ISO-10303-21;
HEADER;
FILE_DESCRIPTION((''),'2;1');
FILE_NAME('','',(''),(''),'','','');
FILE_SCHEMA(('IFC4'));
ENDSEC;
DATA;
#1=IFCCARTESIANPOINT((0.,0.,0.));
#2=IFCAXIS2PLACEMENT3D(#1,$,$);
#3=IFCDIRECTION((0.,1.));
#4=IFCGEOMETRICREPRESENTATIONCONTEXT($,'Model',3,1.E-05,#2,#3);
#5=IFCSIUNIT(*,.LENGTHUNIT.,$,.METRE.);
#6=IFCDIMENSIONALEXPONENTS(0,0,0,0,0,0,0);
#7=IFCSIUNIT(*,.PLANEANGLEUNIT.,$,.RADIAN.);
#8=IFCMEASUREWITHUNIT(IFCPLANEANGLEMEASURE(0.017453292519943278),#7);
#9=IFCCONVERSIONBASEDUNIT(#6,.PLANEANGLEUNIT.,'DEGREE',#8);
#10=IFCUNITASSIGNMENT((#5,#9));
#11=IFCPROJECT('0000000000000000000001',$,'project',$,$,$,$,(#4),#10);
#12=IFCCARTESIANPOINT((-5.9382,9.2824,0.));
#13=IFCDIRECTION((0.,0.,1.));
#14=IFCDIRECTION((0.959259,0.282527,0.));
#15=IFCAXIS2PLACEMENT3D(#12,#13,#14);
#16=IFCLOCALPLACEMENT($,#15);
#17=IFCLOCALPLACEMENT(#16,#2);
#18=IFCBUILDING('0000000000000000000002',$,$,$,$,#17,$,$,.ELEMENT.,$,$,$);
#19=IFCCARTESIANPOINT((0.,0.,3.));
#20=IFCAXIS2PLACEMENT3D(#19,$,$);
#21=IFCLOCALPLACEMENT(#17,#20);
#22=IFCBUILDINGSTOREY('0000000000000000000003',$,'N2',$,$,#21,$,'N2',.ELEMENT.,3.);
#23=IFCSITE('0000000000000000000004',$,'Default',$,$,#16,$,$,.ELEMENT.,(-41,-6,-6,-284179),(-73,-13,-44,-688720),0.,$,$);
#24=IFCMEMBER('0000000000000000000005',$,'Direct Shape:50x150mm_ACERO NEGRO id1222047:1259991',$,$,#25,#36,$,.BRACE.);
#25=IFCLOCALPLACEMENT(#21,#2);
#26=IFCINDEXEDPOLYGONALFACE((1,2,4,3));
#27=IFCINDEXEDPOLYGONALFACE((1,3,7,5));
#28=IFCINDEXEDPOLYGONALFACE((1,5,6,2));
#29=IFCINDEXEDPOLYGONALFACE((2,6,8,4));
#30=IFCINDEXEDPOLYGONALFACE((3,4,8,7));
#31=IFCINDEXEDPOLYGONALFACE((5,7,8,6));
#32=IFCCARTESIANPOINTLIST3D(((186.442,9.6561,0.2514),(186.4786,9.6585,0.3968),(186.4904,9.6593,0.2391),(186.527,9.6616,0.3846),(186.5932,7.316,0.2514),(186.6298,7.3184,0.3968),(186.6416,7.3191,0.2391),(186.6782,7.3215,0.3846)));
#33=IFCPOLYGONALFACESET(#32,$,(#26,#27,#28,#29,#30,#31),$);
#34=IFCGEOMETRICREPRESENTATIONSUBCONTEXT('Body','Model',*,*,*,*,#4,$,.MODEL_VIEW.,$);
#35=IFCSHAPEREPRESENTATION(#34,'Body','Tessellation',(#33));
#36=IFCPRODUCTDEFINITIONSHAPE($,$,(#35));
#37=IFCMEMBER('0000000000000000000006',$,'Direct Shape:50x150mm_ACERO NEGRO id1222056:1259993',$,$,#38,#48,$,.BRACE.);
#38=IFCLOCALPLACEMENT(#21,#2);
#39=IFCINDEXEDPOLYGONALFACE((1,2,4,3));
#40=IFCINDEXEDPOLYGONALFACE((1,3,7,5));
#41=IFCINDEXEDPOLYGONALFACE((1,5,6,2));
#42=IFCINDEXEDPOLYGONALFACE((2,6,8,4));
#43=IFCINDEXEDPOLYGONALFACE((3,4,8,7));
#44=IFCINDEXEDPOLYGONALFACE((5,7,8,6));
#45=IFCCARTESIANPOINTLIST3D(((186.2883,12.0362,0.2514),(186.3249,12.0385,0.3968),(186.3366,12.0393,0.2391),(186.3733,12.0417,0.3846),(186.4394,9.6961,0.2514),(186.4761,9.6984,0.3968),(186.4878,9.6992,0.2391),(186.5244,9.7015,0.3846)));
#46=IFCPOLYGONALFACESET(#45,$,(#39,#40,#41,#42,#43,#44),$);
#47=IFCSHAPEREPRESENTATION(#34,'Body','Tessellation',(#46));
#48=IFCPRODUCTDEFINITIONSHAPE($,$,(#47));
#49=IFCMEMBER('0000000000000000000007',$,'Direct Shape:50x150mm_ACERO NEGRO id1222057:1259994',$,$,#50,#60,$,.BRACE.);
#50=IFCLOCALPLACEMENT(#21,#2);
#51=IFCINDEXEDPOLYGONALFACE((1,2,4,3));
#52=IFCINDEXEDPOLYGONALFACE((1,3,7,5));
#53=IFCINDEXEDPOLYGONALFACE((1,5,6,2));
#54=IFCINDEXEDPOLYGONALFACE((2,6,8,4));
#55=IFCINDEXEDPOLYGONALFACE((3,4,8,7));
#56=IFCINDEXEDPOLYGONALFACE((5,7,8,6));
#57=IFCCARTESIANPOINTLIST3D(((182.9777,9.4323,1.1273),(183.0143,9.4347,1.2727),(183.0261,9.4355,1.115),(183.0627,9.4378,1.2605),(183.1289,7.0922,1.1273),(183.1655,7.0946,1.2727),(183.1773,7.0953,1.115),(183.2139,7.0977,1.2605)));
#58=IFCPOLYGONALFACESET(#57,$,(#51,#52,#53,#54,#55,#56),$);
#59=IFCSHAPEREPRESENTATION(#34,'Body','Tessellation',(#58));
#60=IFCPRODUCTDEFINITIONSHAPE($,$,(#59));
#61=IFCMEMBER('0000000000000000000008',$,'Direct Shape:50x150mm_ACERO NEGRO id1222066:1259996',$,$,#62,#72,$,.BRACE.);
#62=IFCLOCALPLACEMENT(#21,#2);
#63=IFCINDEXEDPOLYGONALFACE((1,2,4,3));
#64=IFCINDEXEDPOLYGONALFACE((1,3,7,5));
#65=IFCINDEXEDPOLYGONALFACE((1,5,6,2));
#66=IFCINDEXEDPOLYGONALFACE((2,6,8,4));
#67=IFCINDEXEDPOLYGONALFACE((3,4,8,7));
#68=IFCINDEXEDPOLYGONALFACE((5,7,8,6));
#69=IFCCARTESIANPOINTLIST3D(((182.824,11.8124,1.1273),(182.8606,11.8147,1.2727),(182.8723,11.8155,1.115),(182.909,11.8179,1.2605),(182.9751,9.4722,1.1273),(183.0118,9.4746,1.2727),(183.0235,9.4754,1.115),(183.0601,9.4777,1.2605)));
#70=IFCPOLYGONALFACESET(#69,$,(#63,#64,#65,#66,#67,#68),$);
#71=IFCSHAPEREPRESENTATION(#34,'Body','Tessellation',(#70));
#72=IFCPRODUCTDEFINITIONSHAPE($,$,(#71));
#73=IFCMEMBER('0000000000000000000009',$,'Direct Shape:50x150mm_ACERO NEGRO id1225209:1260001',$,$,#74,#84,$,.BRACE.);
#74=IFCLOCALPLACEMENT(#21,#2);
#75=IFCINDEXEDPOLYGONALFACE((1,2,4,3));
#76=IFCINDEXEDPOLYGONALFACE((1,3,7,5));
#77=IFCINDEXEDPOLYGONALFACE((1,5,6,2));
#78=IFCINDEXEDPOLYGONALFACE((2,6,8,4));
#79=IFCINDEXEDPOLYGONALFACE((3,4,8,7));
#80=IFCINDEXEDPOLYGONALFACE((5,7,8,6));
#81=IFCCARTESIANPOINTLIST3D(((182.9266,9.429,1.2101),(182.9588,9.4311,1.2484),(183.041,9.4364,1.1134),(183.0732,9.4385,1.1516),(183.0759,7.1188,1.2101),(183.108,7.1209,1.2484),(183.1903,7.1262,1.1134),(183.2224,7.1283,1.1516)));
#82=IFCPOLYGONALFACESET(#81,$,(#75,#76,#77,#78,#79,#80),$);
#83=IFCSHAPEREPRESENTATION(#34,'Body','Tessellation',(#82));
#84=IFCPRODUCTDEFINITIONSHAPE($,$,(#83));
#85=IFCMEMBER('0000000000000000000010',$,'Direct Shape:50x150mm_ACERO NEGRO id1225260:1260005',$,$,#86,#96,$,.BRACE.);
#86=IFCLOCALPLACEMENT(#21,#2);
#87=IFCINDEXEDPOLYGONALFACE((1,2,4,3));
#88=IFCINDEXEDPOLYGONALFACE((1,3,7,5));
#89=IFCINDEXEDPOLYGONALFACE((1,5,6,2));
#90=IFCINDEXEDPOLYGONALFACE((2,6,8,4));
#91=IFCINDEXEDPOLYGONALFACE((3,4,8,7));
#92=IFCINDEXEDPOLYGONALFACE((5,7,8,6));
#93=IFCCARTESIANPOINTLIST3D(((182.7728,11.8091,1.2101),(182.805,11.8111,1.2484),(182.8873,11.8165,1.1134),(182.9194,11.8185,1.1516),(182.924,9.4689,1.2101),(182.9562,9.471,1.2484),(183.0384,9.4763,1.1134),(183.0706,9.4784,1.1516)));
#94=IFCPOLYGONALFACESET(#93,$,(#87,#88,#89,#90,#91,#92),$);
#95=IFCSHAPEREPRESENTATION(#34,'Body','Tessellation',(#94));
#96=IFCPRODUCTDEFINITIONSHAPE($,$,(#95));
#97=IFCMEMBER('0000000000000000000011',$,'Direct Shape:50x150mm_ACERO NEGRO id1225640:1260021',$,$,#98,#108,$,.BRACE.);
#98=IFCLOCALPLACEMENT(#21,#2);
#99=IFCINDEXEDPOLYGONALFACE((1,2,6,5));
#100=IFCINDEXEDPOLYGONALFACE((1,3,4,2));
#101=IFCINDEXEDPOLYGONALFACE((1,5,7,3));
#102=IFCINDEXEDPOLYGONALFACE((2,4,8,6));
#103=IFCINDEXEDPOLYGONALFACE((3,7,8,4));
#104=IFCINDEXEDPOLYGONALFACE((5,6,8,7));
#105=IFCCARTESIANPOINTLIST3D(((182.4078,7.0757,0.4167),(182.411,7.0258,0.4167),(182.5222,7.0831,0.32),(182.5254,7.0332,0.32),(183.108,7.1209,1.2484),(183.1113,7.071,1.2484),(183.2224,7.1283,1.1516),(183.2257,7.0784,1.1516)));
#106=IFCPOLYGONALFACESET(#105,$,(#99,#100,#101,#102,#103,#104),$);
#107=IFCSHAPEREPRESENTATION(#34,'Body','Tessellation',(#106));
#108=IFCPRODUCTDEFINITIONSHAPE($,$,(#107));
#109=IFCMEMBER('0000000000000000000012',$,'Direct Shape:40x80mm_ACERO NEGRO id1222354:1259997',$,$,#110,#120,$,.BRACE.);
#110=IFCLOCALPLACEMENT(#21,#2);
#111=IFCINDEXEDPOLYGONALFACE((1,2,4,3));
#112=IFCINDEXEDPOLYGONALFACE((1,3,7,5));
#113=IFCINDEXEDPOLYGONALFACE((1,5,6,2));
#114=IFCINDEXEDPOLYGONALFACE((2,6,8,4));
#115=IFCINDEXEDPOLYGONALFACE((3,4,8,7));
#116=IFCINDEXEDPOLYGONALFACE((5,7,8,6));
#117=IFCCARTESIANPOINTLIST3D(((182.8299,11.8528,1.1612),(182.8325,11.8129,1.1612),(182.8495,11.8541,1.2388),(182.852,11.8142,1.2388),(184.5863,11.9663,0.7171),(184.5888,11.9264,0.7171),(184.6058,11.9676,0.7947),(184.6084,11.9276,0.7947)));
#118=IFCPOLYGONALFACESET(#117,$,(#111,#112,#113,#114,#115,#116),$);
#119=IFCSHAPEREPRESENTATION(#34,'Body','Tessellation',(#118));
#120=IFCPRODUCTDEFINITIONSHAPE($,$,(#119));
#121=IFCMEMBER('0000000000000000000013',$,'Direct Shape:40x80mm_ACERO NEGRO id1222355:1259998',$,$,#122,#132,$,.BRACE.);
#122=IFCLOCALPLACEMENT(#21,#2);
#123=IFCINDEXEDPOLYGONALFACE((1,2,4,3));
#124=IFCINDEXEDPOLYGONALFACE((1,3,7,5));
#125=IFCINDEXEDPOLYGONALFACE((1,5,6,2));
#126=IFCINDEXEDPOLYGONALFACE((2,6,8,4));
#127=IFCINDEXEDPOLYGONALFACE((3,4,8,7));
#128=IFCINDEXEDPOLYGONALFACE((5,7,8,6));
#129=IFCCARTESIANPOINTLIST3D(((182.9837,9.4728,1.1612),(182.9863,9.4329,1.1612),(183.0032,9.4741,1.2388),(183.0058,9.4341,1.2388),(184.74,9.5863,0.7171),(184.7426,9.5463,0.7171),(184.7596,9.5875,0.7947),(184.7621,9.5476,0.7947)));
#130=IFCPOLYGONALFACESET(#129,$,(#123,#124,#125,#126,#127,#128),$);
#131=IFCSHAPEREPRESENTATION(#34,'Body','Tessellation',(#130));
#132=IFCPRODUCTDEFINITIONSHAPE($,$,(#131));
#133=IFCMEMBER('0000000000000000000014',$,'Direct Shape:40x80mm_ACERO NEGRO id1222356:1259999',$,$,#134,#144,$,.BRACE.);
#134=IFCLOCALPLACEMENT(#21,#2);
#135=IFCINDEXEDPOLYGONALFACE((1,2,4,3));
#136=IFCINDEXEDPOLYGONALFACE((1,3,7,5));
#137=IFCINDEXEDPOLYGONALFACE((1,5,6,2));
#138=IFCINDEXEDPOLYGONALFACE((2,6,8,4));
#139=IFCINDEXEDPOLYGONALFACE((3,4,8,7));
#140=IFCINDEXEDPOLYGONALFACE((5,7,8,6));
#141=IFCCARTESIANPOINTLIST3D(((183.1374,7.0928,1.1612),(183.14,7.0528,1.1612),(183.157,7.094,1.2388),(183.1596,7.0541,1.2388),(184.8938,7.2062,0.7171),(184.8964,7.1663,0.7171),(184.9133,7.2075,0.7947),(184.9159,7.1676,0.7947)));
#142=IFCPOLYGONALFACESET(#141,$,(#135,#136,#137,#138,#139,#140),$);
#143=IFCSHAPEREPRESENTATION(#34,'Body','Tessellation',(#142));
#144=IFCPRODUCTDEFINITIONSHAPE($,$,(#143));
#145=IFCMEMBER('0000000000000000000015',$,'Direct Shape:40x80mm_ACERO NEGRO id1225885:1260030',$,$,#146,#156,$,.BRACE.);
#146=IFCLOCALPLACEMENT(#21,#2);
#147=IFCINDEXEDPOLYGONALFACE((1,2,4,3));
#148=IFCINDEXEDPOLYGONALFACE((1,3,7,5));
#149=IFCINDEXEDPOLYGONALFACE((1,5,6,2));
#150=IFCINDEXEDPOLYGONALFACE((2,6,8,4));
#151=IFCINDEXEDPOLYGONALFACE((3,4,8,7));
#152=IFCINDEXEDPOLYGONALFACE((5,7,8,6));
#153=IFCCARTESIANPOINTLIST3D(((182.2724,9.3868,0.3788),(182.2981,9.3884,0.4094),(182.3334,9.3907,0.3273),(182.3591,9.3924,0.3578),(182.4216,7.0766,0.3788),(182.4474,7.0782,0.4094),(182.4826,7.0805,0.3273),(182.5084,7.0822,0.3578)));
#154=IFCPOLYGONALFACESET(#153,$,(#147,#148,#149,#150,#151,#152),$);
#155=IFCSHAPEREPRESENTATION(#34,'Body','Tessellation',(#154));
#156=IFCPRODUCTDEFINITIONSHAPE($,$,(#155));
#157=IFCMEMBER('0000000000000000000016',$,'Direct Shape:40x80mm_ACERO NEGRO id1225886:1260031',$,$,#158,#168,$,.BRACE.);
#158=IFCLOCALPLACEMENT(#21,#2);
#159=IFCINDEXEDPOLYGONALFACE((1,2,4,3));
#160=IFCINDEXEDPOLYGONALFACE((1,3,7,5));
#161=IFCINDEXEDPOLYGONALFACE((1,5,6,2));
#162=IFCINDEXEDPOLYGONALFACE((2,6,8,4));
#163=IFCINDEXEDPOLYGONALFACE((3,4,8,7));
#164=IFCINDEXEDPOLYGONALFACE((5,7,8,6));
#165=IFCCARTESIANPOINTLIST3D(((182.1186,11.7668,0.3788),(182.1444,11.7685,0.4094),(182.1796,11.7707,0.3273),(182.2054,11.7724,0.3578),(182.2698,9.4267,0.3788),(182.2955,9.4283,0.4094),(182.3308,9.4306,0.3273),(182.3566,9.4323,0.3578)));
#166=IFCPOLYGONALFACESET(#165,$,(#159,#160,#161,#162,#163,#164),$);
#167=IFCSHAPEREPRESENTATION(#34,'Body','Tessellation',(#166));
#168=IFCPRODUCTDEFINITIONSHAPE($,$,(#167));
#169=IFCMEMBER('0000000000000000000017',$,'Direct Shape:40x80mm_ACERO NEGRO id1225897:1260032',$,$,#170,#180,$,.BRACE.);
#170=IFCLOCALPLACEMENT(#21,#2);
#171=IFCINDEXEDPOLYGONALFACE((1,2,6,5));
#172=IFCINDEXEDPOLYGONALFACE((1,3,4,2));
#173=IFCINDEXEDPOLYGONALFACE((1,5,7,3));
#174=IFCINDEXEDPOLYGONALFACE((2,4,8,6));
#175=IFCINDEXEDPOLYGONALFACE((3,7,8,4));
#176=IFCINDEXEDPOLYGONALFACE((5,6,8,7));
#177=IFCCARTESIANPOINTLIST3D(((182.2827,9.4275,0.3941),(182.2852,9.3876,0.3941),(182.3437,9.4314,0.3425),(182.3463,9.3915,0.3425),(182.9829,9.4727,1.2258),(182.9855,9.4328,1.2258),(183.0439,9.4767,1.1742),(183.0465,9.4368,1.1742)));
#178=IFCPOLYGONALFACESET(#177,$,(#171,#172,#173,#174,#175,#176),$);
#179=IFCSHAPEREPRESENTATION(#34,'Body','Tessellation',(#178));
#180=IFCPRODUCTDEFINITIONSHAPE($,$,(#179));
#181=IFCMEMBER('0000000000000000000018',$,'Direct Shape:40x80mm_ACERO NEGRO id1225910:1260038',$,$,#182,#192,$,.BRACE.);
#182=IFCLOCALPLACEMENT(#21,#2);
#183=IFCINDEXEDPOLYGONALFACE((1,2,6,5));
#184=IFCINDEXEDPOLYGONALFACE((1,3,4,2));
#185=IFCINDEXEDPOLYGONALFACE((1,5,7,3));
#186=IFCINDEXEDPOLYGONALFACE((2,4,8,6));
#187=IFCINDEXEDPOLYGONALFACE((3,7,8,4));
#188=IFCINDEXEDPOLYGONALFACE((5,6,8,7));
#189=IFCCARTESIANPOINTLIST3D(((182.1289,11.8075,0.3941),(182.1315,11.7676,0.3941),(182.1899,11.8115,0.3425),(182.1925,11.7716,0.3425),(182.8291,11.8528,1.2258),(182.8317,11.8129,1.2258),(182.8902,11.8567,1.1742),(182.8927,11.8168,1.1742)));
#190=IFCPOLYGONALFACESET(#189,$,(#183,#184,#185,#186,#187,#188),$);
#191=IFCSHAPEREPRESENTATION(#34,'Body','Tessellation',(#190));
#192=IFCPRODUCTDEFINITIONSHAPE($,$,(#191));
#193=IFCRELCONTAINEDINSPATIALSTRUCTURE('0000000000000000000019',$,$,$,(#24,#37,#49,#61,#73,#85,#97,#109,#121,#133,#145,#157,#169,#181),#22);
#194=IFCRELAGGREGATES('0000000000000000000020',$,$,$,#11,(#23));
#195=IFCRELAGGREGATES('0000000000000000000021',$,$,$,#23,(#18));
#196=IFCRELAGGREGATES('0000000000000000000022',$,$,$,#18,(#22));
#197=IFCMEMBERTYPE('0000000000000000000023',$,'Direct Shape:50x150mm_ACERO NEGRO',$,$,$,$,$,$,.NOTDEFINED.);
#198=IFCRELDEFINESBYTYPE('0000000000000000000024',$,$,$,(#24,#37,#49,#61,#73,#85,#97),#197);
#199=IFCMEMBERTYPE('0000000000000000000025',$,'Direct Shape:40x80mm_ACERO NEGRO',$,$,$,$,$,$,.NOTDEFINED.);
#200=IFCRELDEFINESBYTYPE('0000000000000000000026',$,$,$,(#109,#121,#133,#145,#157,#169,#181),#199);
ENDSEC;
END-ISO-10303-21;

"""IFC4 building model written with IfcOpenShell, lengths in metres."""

from ifc_helpers import new_model, entity, si_unit, converted_unit, direction, frame, frame_2d, origin, origin_2d_with_axis, place, context, subcontext, project, spatial, rectangle, extrude, type_object, element, save


model = new_model("IFC4")

# Units and contexts
model_context = context("Model", 3, precision=1e-05, world=origin(), true_north=direction((0.0, 1.0)))
body_context = subcontext(model_context, "Body", "Model", "MODEL_VIEW")
ifc_project = project(units=[si_unit("LENGTHUNIT", "METRE"), converted_unit("PLANEANGLEUNIT", "DEGREE", entity("IfcPlaneAngleMeasure", 0.017453292519943278), si_unit("PLANEANGLEUNIT", "RADIAN"), dimensions=[0, 0, 0, 0, 0, 0, 0])], contexts=[model_context])

# Site, building, storey
site_placement = place(None, frame((-5.9382, 9.2824, 0.0), z_axis=(0.0, 0.0, 1.0), x_axis=(0.959259, 0.282527, 0.0)))
site = spatial("IfcSite", under=ifc_project, at=site_placement, Name="Default", CompositionType="ELEMENT", RefLatitude=(-41, -6, -6, -284179), RefLongitude=(-73, -13, -44, -688720), RefElevation=0.0)
building_placement = place(site_placement, origin())
building = spatial("IfcBuilding", under=site, at=building_placement, CompositionType="ELEMENT")
storey_placement = place(building_placement, frame((0.0, 0.0, 3.0)))
storey = spatial("IfcBuildingStorey", under=building, at=storey_placement, Name="N2", LongName="N2", CompositionType="ELEMENT", Elevation=3.0)

# Members
member_type_1 = type_object("IfcMemberType", Name="Direct Shape:50x150mm_ACERO NEGRO", PredefinedType="NOTDEFINED")
member_1_placement = place(storey_placement, origin())
element("IfcMember", 1, at=member_1_placement, inside=storey, type_object=member_type_1, Name="Direct Shape:50x150mm_ACERO NEGRO id1222047:1259991", PredefinedType="BRACE", context=body_context, shape_type="SweptSolid", body=[
    extrude(rectangle(XDim=0.15, YDim=0.05, at=origin_2d_with_axis()), frame((186.6357, 7.3188, 0.318), z_axis=(-0.064471, 0.99792, 0.0), x_axis=(-0.24414, -0.015773, -0.969612)), (0.0, 0.0, 1.0), 2.345),
])
member_2_placement = place(storey_placement, origin())
element("IfcMember", 2, at=member_2_placement, inside=storey, type_object=member_type_1, Name="Direct Shape:50x150mm_ACERO NEGRO id1222056:1259993", PredefinedType="BRACE", context=body_context, shape_type="SweptSolid", body=[
    extrude(rectangle(XDim=0.15, YDim=0.05, at=origin_2d_with_axis()), frame((186.4819, 9.6988, 0.318), z_axis=(-0.064471, 0.99792, 0.0), x_axis=(-0.24414, -0.015773, -0.969612)), (0.0, 0.0, 1.0), 2.345),
])
member_3_placement = place(storey_placement, origin())
element("IfcMember", 3, at=member_3_placement, inside=storey, type_object=member_type_1, Name="Direct Shape:50x150mm_ACERO NEGRO id1222057:1259994", PredefinedType="BRACE", context=body_context, shape_type="SweptSolid", body=[
    extrude(rectangle(XDim=0.15, YDim=0.05, at=frame_2d((0.0, 0.0), x_axis=(0.0, 1.0))), frame((183.1714, 7.095, 1.1939), z_axis=(-0.064471, 0.99792, 0.0), x_axis=(0.967595, 0.062512, -0.244649)), (0.0, 0.0, 1.0), 2.345),
])
member_4_placement = place(storey_placement, origin())
element("IfcMember", 4, at=member_4_placement, inside=storey, type_object=member_type_1, Name="Direct Shape:50x150mm_ACERO NEGRO id1222066:1259996", PredefinedType="BRACE", context=body_context, shape_type="SweptSolid", body=[
    extrude(rectangle(XDim=0.15, YDim=0.05, at=frame_2d((0.0, 0.0), x_axis=(0.0, 1.0))), frame((183.0176, 9.475, 1.1939), z_axis=(-0.064471, 0.99792, 0.0), x_axis=(0.967595, 0.062512, -0.244649)), (0.0, 0.0, 1.0), 2.345),
])
member_5_placement = place(storey_placement, origin())
element("IfcMember", 5, at=member_5_placement, inside=storey, type_object=member_type_1, Name="Direct Shape:50x150mm_ACERO NEGRO id1225209:1260001", PredefinedType="BRACE", context=body_context, shape_type="SweptSolid", body=[
    extrude(rectangle(XDim=0.05, YDim=0.15, at=frame_2d((0.0, 0.0), x_axis=(0.0, 1.0))), frame((183.1492, 7.1236, 1.1809), z_axis=(-0.064471, 0.99792, 0.0), x_axis=(0.762714, 0.049276, -0.644857)), (0.0, 0.0, 1.0), 2.315),
])
member_6_placement = place(storey_placement, origin())
element("IfcMember", 6, at=member_6_placement, inside=storey, type_object=member_type_1, Name="Direct Shape:50x150mm_ACERO NEGRO id1225260:1260005", PredefinedType="BRACE", context=body_context, shape_type="SweptSolid", body=[
    extrude(rectangle(XDim=0.05, YDim=0.15, at=frame_2d((0.0, 0.0), x_axis=(0.0, 1.0))), frame((182.9973, 9.4737, 1.1809), z_axis=(-0.064471, 0.99792, 0.0), x_axis=(0.762714, 0.049276, -0.644857)), (0.0, 0.0, 1.0), 2.345),
])
member_7_placement = place(storey_placement, origin())
element("IfcMember", 7, at=member_7_placement, inside=storey, type_object=member_type_1, Name="Direct Shape:50x150mm_ACERO NEGRO id1225640:1260021", PredefinedType="BRACE", context=body_context, shape_type="SweptSolid", body=[
    extrude(rectangle(XDim=0.15, YDim=0.05, at=frame_2d((0.0, 0.0), x_axis=(1.0, 0.0))), frame((182.4666, 7.0544, 0.3683), z_axis=(0.643515, 0.041575, 0.764304), x_axis=(0.762714, 0.049276, -0.644857)), (0.0, 0.0, 1.0), 1.0881),
])
member_type_2 = type_object("IfcMemberType", Name="Direct Shape:40x80mm_ACERO NEGRO", PredefinedType="NOTDEFINED")
member_8_placement = place(storey_placement, origin())
element("IfcMember", 8, at=member_8_placement, inside=storey, type_object=member_type_2, Name="Direct Shape:40x80mm_ACERO NEGRO id1222354:1259997", PredefinedType="BRACE", context=body_context, shape_type="SweptSolid", body=[
    extrude(rectangle(XDim=0.08, YDim=0.04, at=frame_2d((0.0, 0.0), x_axis=(1.0, 0.0))), frame((182.841, 11.8335, 1.2), z_axis=(0.967595, 0.062512, -0.244649), x_axis=(-0.24414, -0.015773, -0.969612)), (0.0, 0.0, 1.0), 1.8152),
])
member_9_placement = place(storey_placement, origin())
element("IfcMember", 9, at=member_9_placement, inside=storey, type_object=member_type_2, Name="Direct Shape:40x80mm_ACERO NEGRO id1222355:1259998", PredefinedType="BRACE", context=body_context, shape_type="SweptSolid", body=[
    extrude(rectangle(XDim=0.08, YDim=0.04, at=frame_2d((0.0, 0.0), x_axis=(1.0, 0.0))), frame((182.9947, 9.4535, 1.2), z_axis=(0.967595, 0.062512, -0.244649), x_axis=(-0.24414, -0.015773, -0.969612)), (0.0, 0.0, 1.0), 1.8152),
])
member_10_placement = place(storey_placement, origin())
element("IfcMember", 10, at=member_10_placement, inside=storey, type_object=member_type_2, Name="Direct Shape:40x80mm_ACERO NEGRO id1222356:1259999", PredefinedType="BRACE", context=body_context, shape_type="SweptSolid", body=[
    extrude(rectangle(XDim=0.08, YDim=0.04, at=frame_2d((0.0, 0.0), x_axis=(1.0, 0.0))), frame((183.1485, 7.0734, 1.2), z_axis=(0.967595, 0.062512, -0.244649), x_axis=(-0.24414, -0.015773, -0.969612)), (0.0, 0.0, 1.0), 1.8152),
])
member_11_placement = place(storey_placement, origin())
element("IfcMember", 11, at=member_11_placement, inside=storey, type_object=member_type_2, Name="Direct Shape:40x80mm_ACERO NEGRO id1225885:1260030", PredefinedType="BRACE", context=body_context, shape_type="SweptSolid", body=[
    extrude(rectangle(XDim=0.04, YDim=0.08, at=frame_2d((0.0, 0.0), x_axis=(0.0, 1.0))), frame((182.465, 7.0794, 0.3683), z_axis=(-0.064471, 0.99792, 0.0), x_axis=(0.762714, 0.049276, -0.644857)), (0.0, 0.0, 1.0), 2.315),
])
member_12_placement = place(storey_placement, origin())
element("IfcMember", 12, at=member_12_placement, inside=storey, type_object=member_type_2, Name="Direct Shape:40x80mm_ACERO NEGRO id1225886:1260031", PredefinedType="BRACE", context=body_context, shape_type="SweptSolid", body=[
    extrude(rectangle(XDim=0.04, YDim=0.08, at=frame_2d((0.0, 0.0), x_axis=(0.0, 1.0))), frame((182.3132, 9.4295, 0.3683), z_axis=(-0.064471, 0.99792, 0.0), x_axis=(0.762714, 0.049276, -0.644857)), (0.0, 0.0, 1.0), 2.345),
])
member_13_placement = place(storey_placement, origin())
element("IfcMember", 13, at=member_13_placement, inside=storey, type_object=member_type_2, Name="Direct Shape:40x80mm_ACERO NEGRO id1225897:1260032", PredefinedType="BRACE", context=body_context, shape_type="SweptSolid", body=[
    extrude(rectangle(XDim=0.08, YDim=0.04, at=frame_2d((0.0, 0.0), x_axis=(0.0, 1.0))), frame((182.3145, 9.4095, 0.3683), z_axis=(0.643515, 0.041575, 0.764304), x_axis=(0.064471, -0.99792, 0.0)), (0.0, 0.0, 1.0), 1.0881),
])
member_14_placement = place(storey_placement, origin())
element("IfcMember", 14, at=member_14_placement, inside=storey, type_object=member_type_2, Name="Direct Shape:40x80mm_ACERO NEGRO id1225910:1260038", PredefinedType="BRACE", context=body_context, shape_type="SweptSolid", body=[
    extrude(rectangle(XDim=0.08, YDim=0.04, at=frame_2d((0.0, 0.0), x_axis=(0.0, 1.0))), frame((182.1607, 11.7896, 0.3683), z_axis=(0.643515, 0.041575, 0.764304), x_axis=(0.064471, -0.99792, 0.0)), (0.0, 0.0, 1.0), 1.0881),
])

save(model, "model.ifc")
